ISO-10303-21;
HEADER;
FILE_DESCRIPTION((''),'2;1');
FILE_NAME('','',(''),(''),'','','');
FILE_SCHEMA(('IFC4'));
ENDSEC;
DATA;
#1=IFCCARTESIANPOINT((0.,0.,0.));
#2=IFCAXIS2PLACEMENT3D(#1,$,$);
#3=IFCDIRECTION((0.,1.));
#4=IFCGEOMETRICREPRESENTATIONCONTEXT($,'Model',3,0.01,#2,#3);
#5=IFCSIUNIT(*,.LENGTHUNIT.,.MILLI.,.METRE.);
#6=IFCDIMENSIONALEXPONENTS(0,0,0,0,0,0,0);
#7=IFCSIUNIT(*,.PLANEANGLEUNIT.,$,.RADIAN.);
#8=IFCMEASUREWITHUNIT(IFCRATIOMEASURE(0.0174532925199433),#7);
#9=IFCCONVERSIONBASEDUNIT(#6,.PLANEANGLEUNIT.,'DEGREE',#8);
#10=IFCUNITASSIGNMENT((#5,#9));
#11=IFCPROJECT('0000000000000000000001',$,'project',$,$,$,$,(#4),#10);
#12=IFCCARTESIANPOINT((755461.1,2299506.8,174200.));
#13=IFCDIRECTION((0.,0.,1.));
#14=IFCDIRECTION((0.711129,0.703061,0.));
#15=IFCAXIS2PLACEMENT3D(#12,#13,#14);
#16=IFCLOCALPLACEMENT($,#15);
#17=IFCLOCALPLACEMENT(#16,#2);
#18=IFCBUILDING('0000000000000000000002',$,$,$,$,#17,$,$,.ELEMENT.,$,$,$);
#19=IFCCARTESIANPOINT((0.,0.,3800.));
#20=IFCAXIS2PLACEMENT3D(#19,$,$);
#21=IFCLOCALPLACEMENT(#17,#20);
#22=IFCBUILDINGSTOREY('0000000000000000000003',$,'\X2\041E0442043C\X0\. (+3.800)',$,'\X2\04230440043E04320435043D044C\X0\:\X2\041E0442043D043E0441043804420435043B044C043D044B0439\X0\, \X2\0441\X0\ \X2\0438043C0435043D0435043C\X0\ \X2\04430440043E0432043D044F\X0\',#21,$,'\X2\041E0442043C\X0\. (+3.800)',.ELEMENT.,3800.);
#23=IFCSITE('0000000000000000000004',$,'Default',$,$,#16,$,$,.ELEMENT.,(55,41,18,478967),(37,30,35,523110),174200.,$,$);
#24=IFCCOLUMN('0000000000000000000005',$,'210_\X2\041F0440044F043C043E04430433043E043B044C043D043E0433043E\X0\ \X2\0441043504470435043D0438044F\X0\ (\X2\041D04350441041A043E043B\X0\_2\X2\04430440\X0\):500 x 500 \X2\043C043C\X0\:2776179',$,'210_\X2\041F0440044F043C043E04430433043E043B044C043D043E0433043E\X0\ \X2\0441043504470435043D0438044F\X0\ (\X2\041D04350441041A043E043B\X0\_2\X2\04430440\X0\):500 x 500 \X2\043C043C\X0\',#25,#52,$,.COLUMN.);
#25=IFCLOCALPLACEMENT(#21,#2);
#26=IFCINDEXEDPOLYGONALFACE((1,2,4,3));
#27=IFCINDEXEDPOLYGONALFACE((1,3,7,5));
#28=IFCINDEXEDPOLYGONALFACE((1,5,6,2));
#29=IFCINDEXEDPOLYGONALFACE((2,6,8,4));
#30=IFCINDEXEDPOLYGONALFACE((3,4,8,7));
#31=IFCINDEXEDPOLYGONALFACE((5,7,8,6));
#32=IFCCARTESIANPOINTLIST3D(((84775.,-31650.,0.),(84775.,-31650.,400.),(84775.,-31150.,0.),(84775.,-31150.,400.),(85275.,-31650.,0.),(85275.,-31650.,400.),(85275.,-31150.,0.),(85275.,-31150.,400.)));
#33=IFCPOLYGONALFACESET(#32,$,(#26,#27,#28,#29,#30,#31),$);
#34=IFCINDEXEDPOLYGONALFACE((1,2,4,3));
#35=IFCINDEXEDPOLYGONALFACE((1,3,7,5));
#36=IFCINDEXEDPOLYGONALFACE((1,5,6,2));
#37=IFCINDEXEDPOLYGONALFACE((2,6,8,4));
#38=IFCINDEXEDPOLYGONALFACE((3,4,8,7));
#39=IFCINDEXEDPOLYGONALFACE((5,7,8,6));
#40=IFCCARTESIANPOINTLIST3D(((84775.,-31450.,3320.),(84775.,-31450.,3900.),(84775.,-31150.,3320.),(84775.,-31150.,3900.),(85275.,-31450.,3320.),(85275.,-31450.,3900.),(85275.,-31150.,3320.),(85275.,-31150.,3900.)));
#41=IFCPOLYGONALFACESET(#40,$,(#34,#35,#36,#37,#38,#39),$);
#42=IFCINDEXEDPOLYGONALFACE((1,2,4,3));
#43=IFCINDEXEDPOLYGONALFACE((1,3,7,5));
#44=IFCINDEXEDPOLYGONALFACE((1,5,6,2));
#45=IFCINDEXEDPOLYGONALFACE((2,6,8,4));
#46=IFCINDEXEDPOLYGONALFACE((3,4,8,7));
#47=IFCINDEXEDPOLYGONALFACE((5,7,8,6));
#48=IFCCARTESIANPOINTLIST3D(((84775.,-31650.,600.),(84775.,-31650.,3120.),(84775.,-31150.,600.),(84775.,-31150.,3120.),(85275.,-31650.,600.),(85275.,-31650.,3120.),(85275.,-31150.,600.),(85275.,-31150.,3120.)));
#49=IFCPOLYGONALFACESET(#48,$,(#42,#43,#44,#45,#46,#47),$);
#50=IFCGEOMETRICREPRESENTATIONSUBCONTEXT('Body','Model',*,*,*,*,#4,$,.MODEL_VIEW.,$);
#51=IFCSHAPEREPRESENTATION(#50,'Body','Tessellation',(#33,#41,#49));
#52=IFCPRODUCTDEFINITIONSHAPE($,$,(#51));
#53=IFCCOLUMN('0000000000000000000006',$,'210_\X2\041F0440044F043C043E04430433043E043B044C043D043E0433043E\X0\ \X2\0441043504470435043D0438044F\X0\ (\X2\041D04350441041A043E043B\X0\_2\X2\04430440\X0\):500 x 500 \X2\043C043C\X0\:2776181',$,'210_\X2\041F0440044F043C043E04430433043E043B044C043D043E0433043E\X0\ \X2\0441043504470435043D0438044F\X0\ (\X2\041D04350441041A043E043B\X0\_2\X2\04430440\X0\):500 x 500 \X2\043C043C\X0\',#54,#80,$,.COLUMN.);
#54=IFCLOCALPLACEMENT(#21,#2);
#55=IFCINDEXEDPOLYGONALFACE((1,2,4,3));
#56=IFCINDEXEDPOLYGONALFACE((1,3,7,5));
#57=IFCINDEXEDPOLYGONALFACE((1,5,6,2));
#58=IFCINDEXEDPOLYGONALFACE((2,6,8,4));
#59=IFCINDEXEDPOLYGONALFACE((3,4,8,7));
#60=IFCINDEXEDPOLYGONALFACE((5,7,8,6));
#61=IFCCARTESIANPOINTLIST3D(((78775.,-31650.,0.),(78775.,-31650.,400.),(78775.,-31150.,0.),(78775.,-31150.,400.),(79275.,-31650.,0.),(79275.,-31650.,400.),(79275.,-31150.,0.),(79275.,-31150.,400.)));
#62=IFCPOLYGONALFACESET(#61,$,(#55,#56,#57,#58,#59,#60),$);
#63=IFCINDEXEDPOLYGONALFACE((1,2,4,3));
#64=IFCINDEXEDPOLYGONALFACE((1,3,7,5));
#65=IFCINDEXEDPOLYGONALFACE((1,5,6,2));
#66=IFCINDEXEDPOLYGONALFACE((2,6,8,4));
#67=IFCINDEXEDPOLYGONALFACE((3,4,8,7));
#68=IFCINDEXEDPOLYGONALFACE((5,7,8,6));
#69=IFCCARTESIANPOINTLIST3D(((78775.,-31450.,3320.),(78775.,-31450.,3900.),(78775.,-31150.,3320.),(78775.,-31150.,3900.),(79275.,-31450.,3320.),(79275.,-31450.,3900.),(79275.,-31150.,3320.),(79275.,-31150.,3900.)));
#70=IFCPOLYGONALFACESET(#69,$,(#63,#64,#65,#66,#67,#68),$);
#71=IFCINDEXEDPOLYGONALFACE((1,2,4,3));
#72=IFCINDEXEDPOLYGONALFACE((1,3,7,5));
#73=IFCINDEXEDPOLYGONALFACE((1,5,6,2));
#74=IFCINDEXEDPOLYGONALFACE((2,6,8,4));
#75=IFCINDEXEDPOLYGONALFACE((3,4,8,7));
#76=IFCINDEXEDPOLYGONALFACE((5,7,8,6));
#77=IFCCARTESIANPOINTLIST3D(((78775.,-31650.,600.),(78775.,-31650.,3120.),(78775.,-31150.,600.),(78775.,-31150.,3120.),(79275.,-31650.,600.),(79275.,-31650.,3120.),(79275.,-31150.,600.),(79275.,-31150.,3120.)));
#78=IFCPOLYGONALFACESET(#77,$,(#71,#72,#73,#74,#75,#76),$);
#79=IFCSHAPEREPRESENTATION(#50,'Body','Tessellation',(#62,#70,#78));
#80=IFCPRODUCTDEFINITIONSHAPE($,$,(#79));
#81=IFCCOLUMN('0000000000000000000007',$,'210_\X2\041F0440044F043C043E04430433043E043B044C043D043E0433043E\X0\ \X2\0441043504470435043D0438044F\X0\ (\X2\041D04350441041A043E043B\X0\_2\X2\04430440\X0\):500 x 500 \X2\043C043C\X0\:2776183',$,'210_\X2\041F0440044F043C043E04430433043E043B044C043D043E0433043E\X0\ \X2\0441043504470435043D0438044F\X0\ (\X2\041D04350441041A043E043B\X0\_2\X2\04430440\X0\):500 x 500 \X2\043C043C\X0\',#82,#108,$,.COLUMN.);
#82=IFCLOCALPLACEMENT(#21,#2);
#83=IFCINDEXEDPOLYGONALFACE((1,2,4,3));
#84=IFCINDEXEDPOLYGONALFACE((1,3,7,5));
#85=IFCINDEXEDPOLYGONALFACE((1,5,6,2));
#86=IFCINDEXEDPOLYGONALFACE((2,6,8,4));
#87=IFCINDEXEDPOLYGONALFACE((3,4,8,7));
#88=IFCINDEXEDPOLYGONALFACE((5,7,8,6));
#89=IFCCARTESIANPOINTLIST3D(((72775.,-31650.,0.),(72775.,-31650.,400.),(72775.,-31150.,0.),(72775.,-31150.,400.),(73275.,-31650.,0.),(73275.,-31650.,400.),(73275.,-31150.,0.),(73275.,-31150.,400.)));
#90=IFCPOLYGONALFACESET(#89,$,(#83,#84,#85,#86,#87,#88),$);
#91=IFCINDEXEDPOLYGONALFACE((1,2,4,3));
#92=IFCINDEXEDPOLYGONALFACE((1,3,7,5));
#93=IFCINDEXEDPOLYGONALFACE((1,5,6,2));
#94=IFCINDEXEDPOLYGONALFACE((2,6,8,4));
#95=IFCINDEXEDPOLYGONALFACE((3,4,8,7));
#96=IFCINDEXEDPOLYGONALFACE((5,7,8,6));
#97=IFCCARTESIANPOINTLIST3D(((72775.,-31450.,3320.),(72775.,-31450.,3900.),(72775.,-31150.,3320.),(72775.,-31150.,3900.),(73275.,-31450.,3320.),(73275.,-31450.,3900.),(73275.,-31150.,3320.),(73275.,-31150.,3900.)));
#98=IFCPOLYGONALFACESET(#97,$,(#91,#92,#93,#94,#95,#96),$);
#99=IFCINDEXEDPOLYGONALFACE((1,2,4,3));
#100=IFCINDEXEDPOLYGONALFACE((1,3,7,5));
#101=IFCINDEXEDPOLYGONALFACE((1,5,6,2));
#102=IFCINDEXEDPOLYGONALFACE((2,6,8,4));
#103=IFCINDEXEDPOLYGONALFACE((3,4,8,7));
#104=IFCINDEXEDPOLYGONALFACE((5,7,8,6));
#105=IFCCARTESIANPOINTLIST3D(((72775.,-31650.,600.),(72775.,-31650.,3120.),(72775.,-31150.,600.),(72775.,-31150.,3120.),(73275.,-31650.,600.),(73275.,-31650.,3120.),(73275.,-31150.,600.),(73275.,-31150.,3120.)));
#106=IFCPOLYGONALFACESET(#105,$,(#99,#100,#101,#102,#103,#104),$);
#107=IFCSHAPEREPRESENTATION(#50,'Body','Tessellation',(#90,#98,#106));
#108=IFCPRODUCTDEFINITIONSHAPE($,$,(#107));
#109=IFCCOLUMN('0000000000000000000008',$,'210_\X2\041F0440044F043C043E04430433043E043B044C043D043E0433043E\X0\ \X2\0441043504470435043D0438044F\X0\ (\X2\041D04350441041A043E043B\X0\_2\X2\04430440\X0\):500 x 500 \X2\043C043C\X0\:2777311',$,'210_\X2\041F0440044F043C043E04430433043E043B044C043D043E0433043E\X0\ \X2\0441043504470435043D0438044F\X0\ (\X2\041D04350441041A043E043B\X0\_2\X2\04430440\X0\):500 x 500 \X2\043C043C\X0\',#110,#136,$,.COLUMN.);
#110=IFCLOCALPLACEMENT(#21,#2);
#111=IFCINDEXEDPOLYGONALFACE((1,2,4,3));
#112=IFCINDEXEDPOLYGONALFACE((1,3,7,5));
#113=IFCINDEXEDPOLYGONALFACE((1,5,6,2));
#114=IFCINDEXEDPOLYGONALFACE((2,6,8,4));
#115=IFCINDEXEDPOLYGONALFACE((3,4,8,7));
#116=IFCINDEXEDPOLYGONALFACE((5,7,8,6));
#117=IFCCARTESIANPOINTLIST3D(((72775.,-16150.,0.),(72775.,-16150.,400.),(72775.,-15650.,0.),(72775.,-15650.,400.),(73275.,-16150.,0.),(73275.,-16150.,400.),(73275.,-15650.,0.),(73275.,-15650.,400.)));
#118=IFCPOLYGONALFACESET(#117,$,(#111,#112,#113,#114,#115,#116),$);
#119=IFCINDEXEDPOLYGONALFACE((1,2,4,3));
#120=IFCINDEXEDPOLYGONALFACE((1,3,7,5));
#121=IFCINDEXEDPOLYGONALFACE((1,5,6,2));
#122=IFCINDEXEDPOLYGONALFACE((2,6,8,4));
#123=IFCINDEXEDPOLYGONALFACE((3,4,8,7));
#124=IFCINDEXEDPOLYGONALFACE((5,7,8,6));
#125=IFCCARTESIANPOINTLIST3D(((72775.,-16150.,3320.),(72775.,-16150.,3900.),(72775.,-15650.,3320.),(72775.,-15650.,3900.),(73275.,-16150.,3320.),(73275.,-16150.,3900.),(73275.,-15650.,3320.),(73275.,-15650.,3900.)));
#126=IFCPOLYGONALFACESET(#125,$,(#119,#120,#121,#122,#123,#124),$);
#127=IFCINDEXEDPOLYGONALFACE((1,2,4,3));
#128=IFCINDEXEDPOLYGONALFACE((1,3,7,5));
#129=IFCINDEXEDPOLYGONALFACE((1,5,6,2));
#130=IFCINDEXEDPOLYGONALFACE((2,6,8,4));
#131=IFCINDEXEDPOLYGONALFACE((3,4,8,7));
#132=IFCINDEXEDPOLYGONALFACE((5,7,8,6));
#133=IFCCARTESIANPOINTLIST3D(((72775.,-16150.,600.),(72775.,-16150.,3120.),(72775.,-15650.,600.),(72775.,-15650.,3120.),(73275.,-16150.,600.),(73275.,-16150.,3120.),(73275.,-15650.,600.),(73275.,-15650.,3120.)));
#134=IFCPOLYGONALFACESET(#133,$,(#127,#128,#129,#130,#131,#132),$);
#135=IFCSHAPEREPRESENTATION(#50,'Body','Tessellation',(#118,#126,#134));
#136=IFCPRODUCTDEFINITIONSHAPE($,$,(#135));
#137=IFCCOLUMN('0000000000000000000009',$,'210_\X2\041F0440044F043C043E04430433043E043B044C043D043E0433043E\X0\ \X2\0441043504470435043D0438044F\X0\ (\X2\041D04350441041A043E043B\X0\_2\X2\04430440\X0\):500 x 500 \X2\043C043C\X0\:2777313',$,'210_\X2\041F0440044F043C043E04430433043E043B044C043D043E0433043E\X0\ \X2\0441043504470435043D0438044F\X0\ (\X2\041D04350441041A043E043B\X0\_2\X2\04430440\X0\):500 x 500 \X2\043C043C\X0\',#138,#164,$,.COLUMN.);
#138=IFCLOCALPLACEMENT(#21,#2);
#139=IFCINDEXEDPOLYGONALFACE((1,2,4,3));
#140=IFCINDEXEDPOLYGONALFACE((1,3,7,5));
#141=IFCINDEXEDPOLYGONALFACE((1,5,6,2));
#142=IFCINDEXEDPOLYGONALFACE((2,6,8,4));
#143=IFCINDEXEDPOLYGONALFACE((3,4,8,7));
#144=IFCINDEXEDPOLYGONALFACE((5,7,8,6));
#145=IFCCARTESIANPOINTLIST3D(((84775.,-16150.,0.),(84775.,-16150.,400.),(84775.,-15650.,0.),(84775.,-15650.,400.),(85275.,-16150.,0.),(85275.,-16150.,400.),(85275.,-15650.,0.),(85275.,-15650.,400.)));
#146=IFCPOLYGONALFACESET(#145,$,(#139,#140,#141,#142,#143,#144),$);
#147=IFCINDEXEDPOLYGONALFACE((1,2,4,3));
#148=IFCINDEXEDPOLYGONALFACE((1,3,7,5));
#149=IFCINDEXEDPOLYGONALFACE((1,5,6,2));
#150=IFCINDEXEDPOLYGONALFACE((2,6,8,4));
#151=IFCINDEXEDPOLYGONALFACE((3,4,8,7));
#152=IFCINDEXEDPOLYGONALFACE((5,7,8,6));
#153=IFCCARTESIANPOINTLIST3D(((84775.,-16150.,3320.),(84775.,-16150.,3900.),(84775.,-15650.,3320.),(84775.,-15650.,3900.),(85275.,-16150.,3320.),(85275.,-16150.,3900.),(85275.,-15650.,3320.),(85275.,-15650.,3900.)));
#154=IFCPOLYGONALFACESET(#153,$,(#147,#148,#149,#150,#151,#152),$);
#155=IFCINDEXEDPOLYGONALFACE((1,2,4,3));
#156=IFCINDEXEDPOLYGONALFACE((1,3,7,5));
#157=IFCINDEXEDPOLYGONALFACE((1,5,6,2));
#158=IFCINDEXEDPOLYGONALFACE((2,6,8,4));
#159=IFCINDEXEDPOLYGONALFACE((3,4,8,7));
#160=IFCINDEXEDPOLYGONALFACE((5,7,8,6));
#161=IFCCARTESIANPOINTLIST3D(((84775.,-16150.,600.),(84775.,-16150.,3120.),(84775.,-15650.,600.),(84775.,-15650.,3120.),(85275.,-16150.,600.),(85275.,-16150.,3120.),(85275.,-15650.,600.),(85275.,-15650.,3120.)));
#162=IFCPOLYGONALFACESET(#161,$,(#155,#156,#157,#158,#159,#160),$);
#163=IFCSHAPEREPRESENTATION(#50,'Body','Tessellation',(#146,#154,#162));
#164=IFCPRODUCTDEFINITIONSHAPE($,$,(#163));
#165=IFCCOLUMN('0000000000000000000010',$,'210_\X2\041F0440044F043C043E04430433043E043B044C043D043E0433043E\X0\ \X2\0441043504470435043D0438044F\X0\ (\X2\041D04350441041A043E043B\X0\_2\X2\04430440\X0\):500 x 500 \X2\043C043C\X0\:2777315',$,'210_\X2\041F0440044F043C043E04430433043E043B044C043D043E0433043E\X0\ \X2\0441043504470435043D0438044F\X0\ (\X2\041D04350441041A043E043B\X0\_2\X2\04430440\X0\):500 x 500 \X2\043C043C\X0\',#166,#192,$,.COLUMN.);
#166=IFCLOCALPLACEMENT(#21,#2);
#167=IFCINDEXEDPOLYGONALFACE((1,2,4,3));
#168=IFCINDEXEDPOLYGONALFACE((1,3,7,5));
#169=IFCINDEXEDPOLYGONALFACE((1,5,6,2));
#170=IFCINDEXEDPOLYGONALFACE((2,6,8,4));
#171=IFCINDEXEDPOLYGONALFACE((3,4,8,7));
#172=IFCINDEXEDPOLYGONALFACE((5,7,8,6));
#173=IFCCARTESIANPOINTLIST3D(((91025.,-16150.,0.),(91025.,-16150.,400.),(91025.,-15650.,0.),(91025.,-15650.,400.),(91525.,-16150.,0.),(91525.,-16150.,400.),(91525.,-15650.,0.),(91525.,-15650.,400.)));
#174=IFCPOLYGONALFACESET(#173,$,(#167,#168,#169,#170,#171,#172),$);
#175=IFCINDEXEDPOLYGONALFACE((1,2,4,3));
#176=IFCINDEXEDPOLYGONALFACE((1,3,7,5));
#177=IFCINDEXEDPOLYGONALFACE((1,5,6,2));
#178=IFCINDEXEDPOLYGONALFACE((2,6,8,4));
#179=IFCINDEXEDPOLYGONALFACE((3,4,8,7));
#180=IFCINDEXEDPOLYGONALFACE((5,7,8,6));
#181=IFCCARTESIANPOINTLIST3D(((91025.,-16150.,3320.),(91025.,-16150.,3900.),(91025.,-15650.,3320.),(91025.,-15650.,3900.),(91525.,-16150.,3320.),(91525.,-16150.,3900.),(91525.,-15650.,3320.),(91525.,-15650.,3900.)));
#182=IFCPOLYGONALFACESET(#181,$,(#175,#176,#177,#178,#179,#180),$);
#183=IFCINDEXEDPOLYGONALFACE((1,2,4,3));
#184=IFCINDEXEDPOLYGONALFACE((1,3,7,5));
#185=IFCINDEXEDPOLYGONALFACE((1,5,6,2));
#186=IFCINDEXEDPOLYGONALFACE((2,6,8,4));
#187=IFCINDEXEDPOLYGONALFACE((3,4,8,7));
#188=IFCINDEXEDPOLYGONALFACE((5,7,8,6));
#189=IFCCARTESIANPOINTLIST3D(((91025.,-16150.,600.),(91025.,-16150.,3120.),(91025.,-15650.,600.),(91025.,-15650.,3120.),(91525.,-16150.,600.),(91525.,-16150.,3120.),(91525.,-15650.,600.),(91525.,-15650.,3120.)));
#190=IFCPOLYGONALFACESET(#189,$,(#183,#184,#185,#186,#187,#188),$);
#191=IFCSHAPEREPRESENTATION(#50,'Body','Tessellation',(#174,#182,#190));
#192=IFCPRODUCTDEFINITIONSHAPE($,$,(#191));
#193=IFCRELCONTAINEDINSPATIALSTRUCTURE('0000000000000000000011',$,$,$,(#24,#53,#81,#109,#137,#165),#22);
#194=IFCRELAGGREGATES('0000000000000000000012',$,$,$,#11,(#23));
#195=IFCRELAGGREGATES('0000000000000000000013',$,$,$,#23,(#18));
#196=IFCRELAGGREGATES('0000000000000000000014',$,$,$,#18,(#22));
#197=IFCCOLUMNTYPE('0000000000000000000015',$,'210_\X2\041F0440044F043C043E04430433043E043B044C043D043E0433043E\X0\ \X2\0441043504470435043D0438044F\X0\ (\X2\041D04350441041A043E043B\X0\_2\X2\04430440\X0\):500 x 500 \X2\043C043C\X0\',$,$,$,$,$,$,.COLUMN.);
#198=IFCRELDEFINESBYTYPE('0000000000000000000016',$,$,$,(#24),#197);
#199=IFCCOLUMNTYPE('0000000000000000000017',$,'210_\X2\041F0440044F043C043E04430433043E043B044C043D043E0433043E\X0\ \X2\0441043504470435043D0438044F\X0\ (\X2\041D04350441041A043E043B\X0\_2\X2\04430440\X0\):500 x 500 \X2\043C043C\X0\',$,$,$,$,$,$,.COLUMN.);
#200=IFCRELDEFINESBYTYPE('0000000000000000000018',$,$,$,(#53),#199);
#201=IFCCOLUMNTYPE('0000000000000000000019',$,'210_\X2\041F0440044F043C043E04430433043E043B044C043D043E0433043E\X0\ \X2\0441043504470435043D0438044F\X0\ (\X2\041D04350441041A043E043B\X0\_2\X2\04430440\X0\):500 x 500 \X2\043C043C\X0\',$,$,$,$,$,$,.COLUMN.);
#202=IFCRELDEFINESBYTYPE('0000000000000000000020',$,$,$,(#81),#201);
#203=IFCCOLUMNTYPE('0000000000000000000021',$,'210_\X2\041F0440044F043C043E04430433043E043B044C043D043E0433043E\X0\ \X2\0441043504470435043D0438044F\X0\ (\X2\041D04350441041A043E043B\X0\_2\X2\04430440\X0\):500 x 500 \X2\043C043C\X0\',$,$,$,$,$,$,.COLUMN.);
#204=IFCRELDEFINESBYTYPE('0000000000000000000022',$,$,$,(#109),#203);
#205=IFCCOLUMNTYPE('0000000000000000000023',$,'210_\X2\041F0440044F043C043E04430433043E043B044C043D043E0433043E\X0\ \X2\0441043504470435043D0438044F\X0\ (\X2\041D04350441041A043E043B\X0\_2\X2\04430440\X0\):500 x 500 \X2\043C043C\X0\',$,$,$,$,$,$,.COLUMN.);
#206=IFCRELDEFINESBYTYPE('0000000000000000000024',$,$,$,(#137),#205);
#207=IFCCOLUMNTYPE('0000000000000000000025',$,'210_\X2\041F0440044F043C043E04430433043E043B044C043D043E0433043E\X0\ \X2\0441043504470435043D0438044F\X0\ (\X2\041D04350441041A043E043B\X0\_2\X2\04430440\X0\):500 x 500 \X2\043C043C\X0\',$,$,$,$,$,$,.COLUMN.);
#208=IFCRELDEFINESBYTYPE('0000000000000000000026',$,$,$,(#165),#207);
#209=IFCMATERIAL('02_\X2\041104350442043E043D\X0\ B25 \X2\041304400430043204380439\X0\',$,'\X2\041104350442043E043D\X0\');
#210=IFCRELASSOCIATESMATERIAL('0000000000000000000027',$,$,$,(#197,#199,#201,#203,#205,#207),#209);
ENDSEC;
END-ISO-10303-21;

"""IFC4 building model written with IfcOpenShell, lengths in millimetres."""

from ifc_helpers import new_model, entity, si_unit, converted_unit, direction, frame, origin, place, context, subcontext, project, spatial, indexed_curve, outline, extrude, source, transform, mapped, material, type_object, type_shapes, element, save


model = new_model("IFC4")

# Units and contexts
model_context = context("Model", 3, precision=0.01, world=origin(), true_north=direction((0.0, 1.0)))
body_context = subcontext(model_context, "Body", "Model", "MODEL_VIEW")
ifc_project = project(units=[si_unit("LENGTHUNIT", "METRE", prefix="MILLI"), converted_unit("PLANEANGLEUNIT", "DEGREE", entity("IfcRatioMeasure", 0.0174532925199433), si_unit("PLANEANGLEUNIT", "RADIAN"), dimensions=[0, 0, 0, 0, 0, 0, 0])], contexts=[model_context])

# Site, building, storey
site_placement = place(None, frame((755461.1, 2299506.8, 174200.0), z_axis=(0.0, 0.0, 1.0), x_axis=(0.711129, 0.703061, 0.0)))
site = spatial("IfcSite", under=ifc_project, at=site_placement, Name="Default", CompositionType="ELEMENT", RefLatitude=(55, 41, 18, 478967), RefLongitude=(37, 30, 35, 523110), RefElevation=174200.0)
building_placement = place(site_placement, origin())
building = spatial("IfcBuilding", under=site, at=building_placement, CompositionType="ELEMENT")
storey_placement = place(building_placement, frame((0.0, 0.0, 3800.0)))
storey = spatial("IfcBuildingStorey", under=building, at=storey_placement, Name="Отм. (+3.800)", ObjectType="Уровень:Относительный, с именем уровня", LongName="Отм. (+3.800)", CompositionType="ELEMENT", Elevation=3800.0)

# Columns
ifc_material_1 = material(Name="02_Бетон B25 Гравий", Category="Бетон")
column_type_1 = type_object("IfcColumnType", Name="210_Прямоугольного сечения (НесКол_2ур):500 x 500 мм", PredefinedType="COLUMN", material=ifc_material_1)
shared_shape_1 = source(origin(), body_context, "Body", "SweptSolid", [
    extrude(outline(indexed_curve([(-250.0, -250.0), (250.0, -250.0), (250.0, 250.0), (-250.0, 250.0), (-250.0, -250.0)], self_intersect=False)), frame((85025.0, -31400.0, 3800.0), z_axis=(0.0, 0.0, 1.0), x_axis=(0.0, -1.0, 0.0)), (0.0, 0.0, 1.0), 400.0),
    extrude(outline(indexed_curve([(-150.0, -250.0), (150.0, -250.0), (150.0, 250.0), (-150.0, 250.0), (-150.0, -250.0)], self_intersect=False)), frame((85025.0, -31300.0, 7120.0), z_axis=(0.0, 0.0, 1.0), x_axis=(0.0, -1.0, 0.0)), (0.0, 0.0, 1.0), 580.0),
    extrude(outline(indexed_curve([(-250.0, -250.0), (250.0, -250.0), (250.0, 250.0), (-250.0, 250.0), (-250.0, -250.0)], self_intersect=False)), frame((85025.0, -31400.0, 4400.0), z_axis=(0.0, 0.0, 1.0), x_axis=(0.0, -1.0, 0.0)), (0.0, 0.0, 1.0), 2520.0),
])
type_shapes(column_type_1, [shared_shape_1])
column_1_placement = place(storey_placement, frame((0.0, 0.0, -3800.0)))
element("IfcColumn", 1, at=column_1_placement, inside=storey, type_object=column_type_1, Name="210_Прямоугольного сечения (НесКол_2ур):500 x 500 мм:2776179", ObjectType="210_Прямоугольного сечения (НесКол_2ур):500 x 500 мм", PredefinedType="COLUMN", context=body_context, shape_type="MappedRepresentation", body=[
    mapped(shared_shape_1, transform((0.0, 0.0, 0.0), scale=1.0)),
])
column_type_2 = type_object("IfcColumnType", Name="210_Прямоугольного сечения (НесКол_2ур):500 x 500 мм", PredefinedType="COLUMN", material=ifc_material_1)
shared_shape_2 = source(origin(), body_context, "Body", "SweptSolid", [
    extrude(outline(indexed_curve([(-250.0, -250.0), (250.0, -250.0), (250.0, 250.0), (-250.0, 250.0), (-250.0, -250.0)], self_intersect=False)), frame((79025.0, -31400.0, 3800.0), z_axis=(0.0, 0.0, 1.0), x_axis=(0.0, -1.0, 0.0)), (0.0, 0.0, 1.0), 400.0),
    extrude(outline(indexed_curve([(-150.0, -250.0), (150.0, -250.0), (150.0, 250.0), (-150.0, 250.0), (-150.0, -250.0)], self_intersect=False)), frame((79025.0, -31300.0, 7120.0), z_axis=(0.0, 0.0, 1.0), x_axis=(0.0, -1.0, 0.0)), (0.0, 0.0, 1.0), 580.0),
    extrude(outline(indexed_curve([(-250.0, -250.0), (250.0, -250.0), (250.0, 250.0), (-250.0, 250.0), (-250.0, -250.0)], self_intersect=False)), frame((79025.0, -31400.0, 4400.0), z_axis=(0.0, 0.0, 1.0), x_axis=(0.0, -1.0, 0.0)), (0.0, 0.0, 1.0), 2520.0),
])
type_shapes(column_type_2, [shared_shape_2])
column_2_placement = place(storey_placement, frame((0.0, 0.0, -3800.0)))
element("IfcColumn", 2, at=column_2_placement, inside=storey, type_object=column_type_2, Name="210_Прямоугольного сечения (НесКол_2ур):500 x 500 мм:2776181", ObjectType="210_Прямоугольного сечения (НесКол_2ур):500 x 500 мм", PredefinedType="COLUMN", context=body_context, shape_type="MappedRepresentation", body=[
    mapped(shared_shape_2, transform((0.0, 0.0, 0.0), scale=1.0)),
])
column_type_3 = type_object("IfcColumnType", Name="210_Прямоугольного сечения (НесКол_2ур):500 x 500 мм", PredefinedType="COLUMN", material=ifc_material_1)
shared_shape_3 = source(origin(), body_context, "Body", "SweptSolid", [
    extrude(outline(indexed_curve([(-250.0, -250.0), (250.0, -250.0), (250.0, 250.0), (-250.0, 250.0), (-250.0, -250.0)], self_intersect=False)), frame((73025.0, -31400.0, 3800.0), z_axis=(0.0, 0.0, 1.0), x_axis=(0.0, -1.0, 0.0)), (0.0, 0.0, 1.0), 400.0),
    extrude(outline(indexed_curve([(-150.0, -250.0), (150.0, -250.0), (150.0, 250.0), (-150.0, 250.0), (-150.0, -250.0)], self_intersect=False)), frame((73025.0, -31300.0, 7120.0), z_axis=(0.0, 0.0, 1.0), x_axis=(0.0, -1.0, 0.0)), (0.0, 0.0, 1.0), 580.0),
    extrude(outline(indexed_curve([(-250.0, -250.0), (250.0, -250.0), (250.0, 250.0), (-250.0, 250.0), (-250.0, -250.0)], self_intersect=False)), frame((73025.0, -31400.0, 4400.0), z_axis=(0.0, 0.0, 1.0), x_axis=(0.0, -1.0, 0.0)), (0.0, 0.0, 1.0), 2520.0),
])
type_shapes(column_type_3, [shared_shape_3])
column_3_placement = place(storey_placement, frame((0.0, 0.0, -3800.0)))
element("IfcColumn", 3, at=column_3_placement, inside=storey, type_object=column_type_3, Name="210_Прямоугольного сечения (НесКол_2ур):500 x 500 мм:2776183", ObjectType="210_Прямоугольного сечения (НесКол_2ур):500 x 500 мм", PredefinedType="COLUMN", context=body_context, shape_type="MappedRepresentation", body=[
    mapped(shared_shape_3, transform((0.0, 0.0, 0.0), scale=1.0)),
])
column_type_4 = type_object("IfcColumnType", Name="210_Прямоугольного сечения (НесКол_2ур):500 x 500 мм", PredefinedType="COLUMN", material=ifc_material_1)
shared_shape_4 = source(origin(), body_context, "Body", "SweptSolid", [
    extrude(outline(indexed_curve([(-250.0, -250.0), (250.0, -250.0), (250.0, 250.0), (-250.0, 250.0), (-250.0, -250.0)], self_intersect=False)), frame((73025.0, -15900.0, 3800.0), z_axis=(0.0, 0.0, 1.0), x_axis=(0.0, -1.0, 0.0)), (0.0, 0.0, 1.0), 400.0),
    extrude(outline(indexed_curve([(-250.0, -250.0), (250.0, -250.0), (250.0, 250.0), (-250.0, 250.0), (-250.0, -250.0)], self_intersect=False)), frame((73025.0, -15900.0, 7120.0), z_axis=(0.0, 0.0, 1.0), x_axis=(0.0, -1.0, 0.0)), (0.0, 0.0, 1.0), 580.0),
    extrude(outline(indexed_curve([(-250.0, -250.0), (250.0, -250.0), (250.0, 250.0), (-250.0, 250.0), (-250.0, -250.0)], self_intersect=False)), frame((73025.0, -15900.0, 4400.0), z_axis=(0.0, 0.0, 1.0), x_axis=(0.0, -1.0, 0.0)), (0.0, 0.0, 1.0), 2520.0),
])
type_shapes(column_type_4, [shared_shape_4])
column_4_placement = place(storey_placement, frame((0.0, 0.0, -3800.0)))
element("IfcColumn", 4, at=column_4_placement, inside=storey, type_object=column_type_4, Name="210_Прямоугольного сечения (НесКол_2ур):500 x 500 мм:2777311", ObjectType="210_Прямоугольного сечения (НесКол_2ур):500 x 500 мм", PredefinedType="COLUMN", context=body_context, shape_type="MappedRepresentation", body=[
    mapped(shared_shape_4, transform((0.0, 0.0, 0.0), scale=1.0)),
])
column_type_5 = type_object("IfcColumnType", Name="210_Прямоугольного сечения (НесКол_2ур):500 x 500 мм", PredefinedType="COLUMN", material=ifc_material_1)
shared_shape_5 = source(origin(), body_context, "Body", "SweptSolid", [
    extrude(outline(indexed_curve([(-250.0, -250.0), (250.0, -250.0), (250.0, 250.0), (-250.0, 250.0), (-250.0, -250.0)], self_intersect=False)), frame((85025.0, -15900.0, 3800.0), z_axis=(0.0, 0.0, 1.0), x_axis=(0.0, -1.0, 0.0)), (0.0, 0.0, 1.0), 400.0),
    extrude(outline(indexed_curve([(-250.0, -250.0), (250.0, -250.0), (250.0, 250.0), (-250.0, 250.0), (-250.0, -250.0)], self_intersect=False)), frame((85025.0, -15900.0, 7120.0), z_axis=(0.0, 0.0, 1.0), x_axis=(0.0, -1.0, 0.0)), (0.0, 0.0, 1.0), 580.0),
    extrude(outline(indexed_curve([(-250.0, -250.0), (250.0, -250.0), (250.0, 250.0), (-250.0, 250.0), (-250.0, -250.0)], self_intersect=False)), frame((85025.0, -15900.0, 4400.0), z_axis=(0.0, 0.0, 1.0), x_axis=(0.0, -1.0, 0.0)), (0.0, 0.0, 1.0), 2520.0),
])
type_shapes(column_type_5, [shared_shape_5])
column_5_placement = place(storey_placement, frame((0.0, 0.0, -3800.0)))
element("IfcColumn", 5, at=column_5_placement, inside=storey, type_object=column_type_5, Name="210_Прямоугольного сечения (НесКол_2ур):500 x 500 мм:2777313", ObjectType="210_Прямоугольного сечения (НесКол_2ур):500 x 500 мм", PredefinedType="COLUMN", context=body_context, shape_type="MappedRepresentation", body=[
    mapped(shared_shape_5, transform((0.0, 0.0, 0.0), scale=1.0)),
])
column_type_6 = type_object("IfcColumnType", Name="210_Прямоугольного сечения (НесКол_2ур):500 x 500 мм", PredefinedType="COLUMN", material=ifc_material_1)
shared_shape_6 = source(origin(), body_context, "Body", "SweptSolid", [
    extrude(outline(indexed_curve([(-250.0, -250.0), (250.0, -250.0), (250.0, 250.0), (-250.0, 250.0), (-250.0, -250.0)], self_intersect=False)), frame((91275.0, -15900.0, 3800.0), z_axis=(0.0, 0.0, 1.0), x_axis=(0.0, -1.0, 0.0)), (0.0, 0.0, 1.0), 400.0),
    extrude(outline(indexed_curve([(-250.0, -250.0), (250.0, -250.0), (250.0, 250.0), (-250.0, 250.0), (-250.0, -250.0)], self_intersect=False)), frame((91275.0, -15900.0, 7120.0), z_axis=(0.0, 0.0, 1.0), x_axis=(0.0, -1.0, 0.0)), (0.0, 0.0, 1.0), 580.0),
    extrude(outline(indexed_curve([(-250.0, -250.0), (250.0, -250.0), (250.0, 250.0), (-250.0, 250.0), (-250.0, -250.0)], self_intersect=False)), frame((91275.0, -15900.0, 4400.0), z_axis=(0.0, 0.0, 1.0), x_axis=(0.0, -1.0, 0.0)), (0.0, 0.0, 1.0), 2520.0),
])
type_shapes(column_type_6, [shared_shape_6])
column_6_placement = place(storey_placement, frame((0.0, 0.0, -3800.0)))
element("IfcColumn", 6, at=column_6_placement, inside=storey, type_object=column_type_6, Name="210_Прямоугольного сечения (НесКол_2ур):500 x 500 мм:2777315", ObjectType="210_Прямоугольного сечения (НесКол_2ур):500 x 500 мм", PredefinedType="COLUMN", context=body_context, shape_type="MappedRepresentation", body=[
    mapped(shared_shape_6, transform((0.0, 0.0, 0.0), scale=1.0)),
])

save(model, "model.ifc")
